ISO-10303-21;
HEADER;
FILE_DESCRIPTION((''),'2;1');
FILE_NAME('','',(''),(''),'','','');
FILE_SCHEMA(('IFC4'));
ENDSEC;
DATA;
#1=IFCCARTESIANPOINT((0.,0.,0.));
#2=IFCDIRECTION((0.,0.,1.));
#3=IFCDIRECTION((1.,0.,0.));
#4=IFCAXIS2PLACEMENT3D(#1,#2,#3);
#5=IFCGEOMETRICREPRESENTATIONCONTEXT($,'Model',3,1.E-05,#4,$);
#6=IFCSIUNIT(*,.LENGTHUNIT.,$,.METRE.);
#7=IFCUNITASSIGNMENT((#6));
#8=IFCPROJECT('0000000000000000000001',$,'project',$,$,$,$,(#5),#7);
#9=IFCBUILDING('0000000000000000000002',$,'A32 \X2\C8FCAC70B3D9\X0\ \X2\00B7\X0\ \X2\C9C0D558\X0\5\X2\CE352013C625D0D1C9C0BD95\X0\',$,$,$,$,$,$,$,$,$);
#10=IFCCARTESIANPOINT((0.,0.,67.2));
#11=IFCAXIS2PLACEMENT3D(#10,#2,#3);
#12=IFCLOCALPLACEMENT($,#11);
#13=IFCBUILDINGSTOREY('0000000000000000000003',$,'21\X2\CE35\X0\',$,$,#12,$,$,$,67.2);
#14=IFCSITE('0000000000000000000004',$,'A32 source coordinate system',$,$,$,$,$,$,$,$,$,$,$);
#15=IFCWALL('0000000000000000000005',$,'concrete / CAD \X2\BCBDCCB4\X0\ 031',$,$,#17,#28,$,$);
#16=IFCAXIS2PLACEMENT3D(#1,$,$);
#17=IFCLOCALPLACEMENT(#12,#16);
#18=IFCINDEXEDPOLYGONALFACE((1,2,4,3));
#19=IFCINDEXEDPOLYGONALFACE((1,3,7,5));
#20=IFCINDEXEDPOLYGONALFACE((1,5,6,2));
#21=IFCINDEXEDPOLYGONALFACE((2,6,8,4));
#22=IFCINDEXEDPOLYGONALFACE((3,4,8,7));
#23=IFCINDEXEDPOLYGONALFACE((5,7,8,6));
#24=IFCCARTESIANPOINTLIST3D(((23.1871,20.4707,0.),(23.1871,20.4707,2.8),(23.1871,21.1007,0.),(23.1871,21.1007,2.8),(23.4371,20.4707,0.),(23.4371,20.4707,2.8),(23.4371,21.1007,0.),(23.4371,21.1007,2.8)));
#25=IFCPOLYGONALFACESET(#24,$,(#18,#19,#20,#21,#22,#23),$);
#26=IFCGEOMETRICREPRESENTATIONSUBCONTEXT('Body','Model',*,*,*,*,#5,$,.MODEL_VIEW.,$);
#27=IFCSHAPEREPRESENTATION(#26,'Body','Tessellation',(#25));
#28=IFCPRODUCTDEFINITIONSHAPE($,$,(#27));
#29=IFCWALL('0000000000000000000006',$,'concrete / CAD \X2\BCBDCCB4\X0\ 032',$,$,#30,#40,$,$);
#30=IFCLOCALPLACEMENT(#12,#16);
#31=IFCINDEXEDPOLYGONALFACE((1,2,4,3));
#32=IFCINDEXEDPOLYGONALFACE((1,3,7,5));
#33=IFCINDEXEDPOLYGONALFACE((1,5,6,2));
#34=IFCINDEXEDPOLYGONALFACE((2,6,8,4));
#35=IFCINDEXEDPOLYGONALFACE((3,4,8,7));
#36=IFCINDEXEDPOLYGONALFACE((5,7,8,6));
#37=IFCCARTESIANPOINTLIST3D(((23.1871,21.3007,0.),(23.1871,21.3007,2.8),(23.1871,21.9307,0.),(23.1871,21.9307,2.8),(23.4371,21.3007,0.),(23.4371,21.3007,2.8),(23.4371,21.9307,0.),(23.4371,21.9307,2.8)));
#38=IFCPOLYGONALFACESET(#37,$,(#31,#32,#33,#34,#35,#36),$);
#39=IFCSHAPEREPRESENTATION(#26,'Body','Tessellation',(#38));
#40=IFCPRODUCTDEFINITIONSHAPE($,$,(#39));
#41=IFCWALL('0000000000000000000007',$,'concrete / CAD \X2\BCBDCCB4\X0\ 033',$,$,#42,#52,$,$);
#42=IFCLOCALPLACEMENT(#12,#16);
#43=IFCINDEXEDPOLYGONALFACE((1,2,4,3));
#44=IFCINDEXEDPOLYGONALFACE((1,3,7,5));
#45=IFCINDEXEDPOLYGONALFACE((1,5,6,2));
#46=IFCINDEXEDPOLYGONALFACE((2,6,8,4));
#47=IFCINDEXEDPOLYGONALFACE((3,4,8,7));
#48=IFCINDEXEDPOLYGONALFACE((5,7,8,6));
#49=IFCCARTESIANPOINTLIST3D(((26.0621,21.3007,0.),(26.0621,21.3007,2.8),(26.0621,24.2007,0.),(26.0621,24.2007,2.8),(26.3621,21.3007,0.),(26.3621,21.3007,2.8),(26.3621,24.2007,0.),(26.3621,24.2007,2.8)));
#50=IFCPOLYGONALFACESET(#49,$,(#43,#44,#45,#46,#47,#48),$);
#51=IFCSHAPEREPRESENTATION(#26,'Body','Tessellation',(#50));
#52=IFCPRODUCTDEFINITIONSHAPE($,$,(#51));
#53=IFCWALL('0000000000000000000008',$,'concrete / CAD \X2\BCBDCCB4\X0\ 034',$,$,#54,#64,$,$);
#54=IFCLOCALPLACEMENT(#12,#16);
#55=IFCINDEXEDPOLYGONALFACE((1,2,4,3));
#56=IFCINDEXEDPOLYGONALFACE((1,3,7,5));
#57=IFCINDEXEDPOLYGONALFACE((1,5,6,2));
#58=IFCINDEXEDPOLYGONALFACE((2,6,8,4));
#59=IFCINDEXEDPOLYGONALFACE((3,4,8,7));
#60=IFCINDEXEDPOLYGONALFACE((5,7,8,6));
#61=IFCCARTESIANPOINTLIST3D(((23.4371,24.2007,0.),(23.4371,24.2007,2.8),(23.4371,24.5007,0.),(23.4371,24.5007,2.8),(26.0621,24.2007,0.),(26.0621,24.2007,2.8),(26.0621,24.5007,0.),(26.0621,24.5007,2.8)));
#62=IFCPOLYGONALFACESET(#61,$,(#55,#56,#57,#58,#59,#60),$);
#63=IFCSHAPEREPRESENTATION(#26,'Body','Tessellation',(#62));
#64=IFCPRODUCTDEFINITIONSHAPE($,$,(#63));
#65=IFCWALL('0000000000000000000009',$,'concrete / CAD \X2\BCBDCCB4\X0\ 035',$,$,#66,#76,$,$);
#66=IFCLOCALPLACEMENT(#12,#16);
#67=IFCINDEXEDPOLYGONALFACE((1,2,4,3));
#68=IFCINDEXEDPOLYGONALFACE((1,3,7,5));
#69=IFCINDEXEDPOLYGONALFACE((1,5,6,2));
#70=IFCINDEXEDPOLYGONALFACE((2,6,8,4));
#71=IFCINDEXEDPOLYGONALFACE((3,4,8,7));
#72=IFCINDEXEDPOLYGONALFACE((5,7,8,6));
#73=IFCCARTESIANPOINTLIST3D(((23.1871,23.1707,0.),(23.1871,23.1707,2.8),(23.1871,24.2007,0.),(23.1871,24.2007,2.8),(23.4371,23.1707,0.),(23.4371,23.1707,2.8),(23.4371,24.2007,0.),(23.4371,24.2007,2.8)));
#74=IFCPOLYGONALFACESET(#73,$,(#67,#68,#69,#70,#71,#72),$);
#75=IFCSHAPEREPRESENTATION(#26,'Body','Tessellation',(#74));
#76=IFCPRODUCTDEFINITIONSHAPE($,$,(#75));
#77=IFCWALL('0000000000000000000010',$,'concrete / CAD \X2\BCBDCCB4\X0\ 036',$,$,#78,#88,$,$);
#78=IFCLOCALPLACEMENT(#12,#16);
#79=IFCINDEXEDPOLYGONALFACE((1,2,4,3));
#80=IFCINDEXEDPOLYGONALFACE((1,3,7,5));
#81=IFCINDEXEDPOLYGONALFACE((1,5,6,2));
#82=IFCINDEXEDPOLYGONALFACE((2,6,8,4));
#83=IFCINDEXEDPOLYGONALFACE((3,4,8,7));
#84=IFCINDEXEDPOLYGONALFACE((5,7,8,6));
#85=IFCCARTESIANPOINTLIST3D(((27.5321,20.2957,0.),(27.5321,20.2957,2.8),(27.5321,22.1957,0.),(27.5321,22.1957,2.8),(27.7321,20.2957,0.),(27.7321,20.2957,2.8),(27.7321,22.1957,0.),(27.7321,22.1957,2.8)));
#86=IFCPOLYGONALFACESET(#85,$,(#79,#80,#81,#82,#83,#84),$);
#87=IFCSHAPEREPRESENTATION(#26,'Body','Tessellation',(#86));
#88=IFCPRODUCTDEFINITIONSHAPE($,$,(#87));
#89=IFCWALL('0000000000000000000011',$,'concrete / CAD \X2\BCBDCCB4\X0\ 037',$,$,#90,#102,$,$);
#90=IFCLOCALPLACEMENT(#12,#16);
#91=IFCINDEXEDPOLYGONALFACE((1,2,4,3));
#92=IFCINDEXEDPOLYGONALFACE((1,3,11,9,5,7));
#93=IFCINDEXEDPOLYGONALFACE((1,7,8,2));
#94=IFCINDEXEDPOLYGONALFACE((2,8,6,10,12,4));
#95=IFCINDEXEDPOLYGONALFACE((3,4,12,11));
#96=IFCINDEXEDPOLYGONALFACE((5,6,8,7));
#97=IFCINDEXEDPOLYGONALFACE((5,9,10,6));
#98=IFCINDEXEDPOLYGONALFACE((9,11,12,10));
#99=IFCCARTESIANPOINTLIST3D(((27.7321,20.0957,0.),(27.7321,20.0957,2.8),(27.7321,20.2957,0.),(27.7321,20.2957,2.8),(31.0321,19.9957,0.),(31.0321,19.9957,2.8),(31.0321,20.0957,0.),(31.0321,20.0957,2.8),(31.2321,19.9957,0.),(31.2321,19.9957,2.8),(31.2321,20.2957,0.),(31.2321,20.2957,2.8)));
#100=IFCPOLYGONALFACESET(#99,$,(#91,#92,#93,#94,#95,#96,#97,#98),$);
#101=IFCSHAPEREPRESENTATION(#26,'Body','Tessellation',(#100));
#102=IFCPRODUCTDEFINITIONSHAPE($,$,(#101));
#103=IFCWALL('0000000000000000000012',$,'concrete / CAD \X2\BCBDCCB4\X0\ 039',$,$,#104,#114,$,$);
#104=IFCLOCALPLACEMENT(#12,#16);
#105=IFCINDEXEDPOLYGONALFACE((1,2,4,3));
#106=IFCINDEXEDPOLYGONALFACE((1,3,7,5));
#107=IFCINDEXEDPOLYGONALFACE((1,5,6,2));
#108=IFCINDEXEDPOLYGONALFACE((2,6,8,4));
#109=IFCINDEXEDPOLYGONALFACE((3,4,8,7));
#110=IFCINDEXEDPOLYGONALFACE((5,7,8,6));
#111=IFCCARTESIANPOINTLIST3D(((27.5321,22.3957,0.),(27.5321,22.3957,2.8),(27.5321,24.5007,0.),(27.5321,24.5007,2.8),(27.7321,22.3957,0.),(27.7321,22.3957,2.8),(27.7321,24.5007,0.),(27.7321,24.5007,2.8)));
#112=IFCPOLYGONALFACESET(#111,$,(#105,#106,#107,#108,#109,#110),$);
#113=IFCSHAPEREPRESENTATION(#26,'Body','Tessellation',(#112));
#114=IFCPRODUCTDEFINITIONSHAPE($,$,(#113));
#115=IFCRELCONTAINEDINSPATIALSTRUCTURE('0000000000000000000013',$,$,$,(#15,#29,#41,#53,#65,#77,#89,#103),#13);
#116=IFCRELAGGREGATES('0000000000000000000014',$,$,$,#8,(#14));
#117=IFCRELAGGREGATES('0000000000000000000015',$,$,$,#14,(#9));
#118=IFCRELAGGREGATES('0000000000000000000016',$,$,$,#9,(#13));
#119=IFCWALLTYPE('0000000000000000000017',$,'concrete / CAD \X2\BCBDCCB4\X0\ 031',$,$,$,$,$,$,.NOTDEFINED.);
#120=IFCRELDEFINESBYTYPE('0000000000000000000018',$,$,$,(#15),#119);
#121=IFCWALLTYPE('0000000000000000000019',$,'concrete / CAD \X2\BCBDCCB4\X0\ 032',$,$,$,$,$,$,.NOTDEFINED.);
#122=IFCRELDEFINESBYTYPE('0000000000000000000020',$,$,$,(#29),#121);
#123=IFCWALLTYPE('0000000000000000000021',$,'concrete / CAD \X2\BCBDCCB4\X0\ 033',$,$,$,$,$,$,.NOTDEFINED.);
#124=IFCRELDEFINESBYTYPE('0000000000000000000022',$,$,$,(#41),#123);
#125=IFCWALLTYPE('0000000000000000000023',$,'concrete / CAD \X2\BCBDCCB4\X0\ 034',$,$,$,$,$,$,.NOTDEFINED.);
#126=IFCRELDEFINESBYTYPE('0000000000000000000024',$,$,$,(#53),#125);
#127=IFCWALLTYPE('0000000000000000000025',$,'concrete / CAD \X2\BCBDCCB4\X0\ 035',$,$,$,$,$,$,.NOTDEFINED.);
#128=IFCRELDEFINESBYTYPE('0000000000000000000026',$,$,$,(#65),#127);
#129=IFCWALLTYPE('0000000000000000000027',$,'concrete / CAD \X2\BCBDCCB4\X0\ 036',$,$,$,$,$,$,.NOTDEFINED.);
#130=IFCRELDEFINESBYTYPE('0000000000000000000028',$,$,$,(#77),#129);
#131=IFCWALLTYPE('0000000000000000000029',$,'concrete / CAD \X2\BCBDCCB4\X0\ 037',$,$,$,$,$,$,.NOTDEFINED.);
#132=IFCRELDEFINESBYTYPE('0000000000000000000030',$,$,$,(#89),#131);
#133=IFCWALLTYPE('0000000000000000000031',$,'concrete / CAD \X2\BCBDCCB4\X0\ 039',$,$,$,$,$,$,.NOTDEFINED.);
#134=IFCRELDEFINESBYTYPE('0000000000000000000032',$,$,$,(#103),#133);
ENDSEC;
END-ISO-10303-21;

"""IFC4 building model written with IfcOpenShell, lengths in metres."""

from ifc_helpers import new_model, si_unit, frame, origin, origin_with_axes, place, context, subcontext, project, spatial, polyline, outline, extrude, source, transform, mapped, type_object, type_shapes, element, save


model = new_model("IFC4")

# Units and contexts
model_context = context("Model", 3, precision=1e-05, world=origin_with_axes())
body_context = subcontext(model_context, "Body", "Model", "MODEL_VIEW")
ifc_project = project(units=[si_unit("LENGTHUNIT", "METRE")], contexts=[model_context])

# Site, building, storey
site = spatial("IfcSite", under=ifc_project, Name="A32 source coordinate system")
building = spatial("IfcBuilding", under=site, Name="A32 주거동 · 지하5층–옥탑지붕")
storey_placement = place(None, frame((0.0, 0.0, 67.2), z_axis=(0.0, 0.0, 1.0), x_axis=(1.0, 0.0, 0.0)))
storey = spatial("IfcBuildingStorey", under=building, at=storey_placement, Name="21층", Elevation=67.2)

# Walls
wall_type_1 = type_object("IfcWallType", Name="concrete / CAD 벽체 031", PredefinedType="NOTDEFINED")
shared_shape_1 = source(origin(), body_context, "Body", "SweptSolid", [
    extrude(outline(polyline([(23.1871, 20.4707), (23.1871, 21.1007), (23.4371, 21.1007), (23.4371, 20.4707), (23.1871, 20.4707)])), origin(), (0.0, 0.0, 1.0), 2.8),
])
type_shapes(wall_type_1, [shared_shape_1])
wall_1_placement = place(storey_placement, origin_with_axes())
element("IfcWall", 1, at=wall_1_placement, inside=storey, type_object=wall_type_1, Name="concrete / CAD 벽체 031", context=body_context, shape_type="MappedRepresentation", body=[
    mapped(shared_shape_1, transform((0.0, 0.0, 0.0), scale=1.0)),
])
wall_type_2 = type_object("IfcWallType", Name="concrete / CAD 벽체 032", PredefinedType="NOTDEFINED")
shared_shape_2 = source(origin(), body_context, "Body", "SweptSolid", [
    extrude(outline(polyline([(23.4371, 21.9307), (23.4371, 21.3007), (23.1871, 21.3007), (23.1871, 21.9307), (23.4371, 21.9307)])), origin(), (0.0, 0.0, 1.0), 2.8),
])
type_shapes(wall_type_2, [shared_shape_2])
wall_2_placement = place(storey_placement, origin_with_axes())
element("IfcWall", 2, at=wall_2_placement, inside=storey, type_object=wall_type_2, Name="concrete / CAD 벽체 032", context=body_context, shape_type="MappedRepresentation", body=[
    mapped(shared_shape_2, transform((0.0, 0.0, 0.0), scale=1.0)),
])
wall_type_3 = type_object("IfcWallType", Name="concrete / CAD 벽체 033", PredefinedType="NOTDEFINED")
shared_shape_3 = source(origin(), body_context, "Body", "SweptSolid", [
    extrude(outline(polyline([(26.3621, 24.2007), (26.3621, 21.3007), (26.0621, 21.3007), (26.0621, 24.2007), (26.3621, 24.2007)])), origin(), (0.0, 0.0, 1.0), 2.8),
])
type_shapes(wall_type_3, [shared_shape_3])
wall_3_placement = place(storey_placement, origin_with_axes())
element("IfcWall", 3, at=wall_3_placement, inside=storey, type_object=wall_type_3, Name="concrete / CAD 벽체 033", context=body_context, shape_type="MappedRepresentation", body=[
    mapped(shared_shape_3, transform((0.0, 0.0, 0.0), scale=1.0)),
])
wall_type_4 = type_object("IfcWallType", Name="concrete / CAD 벽체 034", PredefinedType="NOTDEFINED")
shared_shape_4 = source(origin(), body_context, "Body", "SweptSolid", [
    extrude(outline(polyline([(23.4371, 24.5007), (26.0621, 24.5007), (26.0621, 24.2007), (23.4371, 24.2007), (23.4371, 24.5007)])), origin(), (0.0, 0.0, 1.0), 2.8),
])
type_shapes(wall_type_4, [shared_shape_4])
wall_4_placement = place(storey_placement, origin_with_axes())
element("IfcWall", 4, at=wall_4_placement, inside=storey, type_object=wall_type_4, Name="concrete / CAD 벽체 034", context=body_context, shape_type="MappedRepresentation", body=[
    mapped(shared_shape_4, transform((0.0, 0.0, 0.0), scale=1.0)),
])
wall_type_5 = type_object("IfcWallType", Name="concrete / CAD 벽체 035", PredefinedType="NOTDEFINED")
shared_shape_5 = source(origin(), body_context, "Body", "SweptSolid", [
    extrude(outline(polyline([(23.1871, 23.1707), (23.1871, 24.2007), (23.4371, 24.2007), (23.4371, 23.1707), (23.1871, 23.1707)])), origin(), (0.0, 0.0, 1.0), 2.8),
])
type_shapes(wall_type_5, [shared_shape_5])
wall_5_placement = place(storey_placement, origin_with_axes())
element("IfcWall", 5, at=wall_5_placement, inside=storey, type_object=wall_type_5, Name="concrete / CAD 벽체 035", context=body_context, shape_type="MappedRepresentation", body=[
    mapped(shared_shape_5, transform((0.0, 0.0, 0.0), scale=1.0)),
])
wall_type_6 = type_object("IfcWallType", Name="concrete / CAD 벽체 036", PredefinedType="NOTDEFINED")
shared_shape_6 = source(origin(), body_context, "Body", "SweptSolid", [
    extrude(outline(polyline([(27.7321, 22.1957), (27.7321, 20.2957), (27.5321, 20.2957), (27.5321, 22.1957), (27.7321, 22.1957)])), origin(), (0.0, 0.0, 1.0), 2.8),
])
type_shapes(wall_type_6, [shared_shape_6])
wall_6_placement = place(storey_placement, origin_with_axes())
element("IfcWall", 6, at=wall_6_placement, inside=storey, type_object=wall_type_6, Name="concrete / CAD 벽체 036", context=body_context, shape_type="MappedRepresentation", body=[
    mapped(shared_shape_6, transform((0.0, 0.0, 0.0), scale=1.0)),
])
wall_type_7 = type_object("IfcWallType", Name="concrete / CAD 벽체 037", PredefinedType="NOTDEFINED")
shared_shape_7 = source(origin(), body_context, "Body", "SweptSolid", [
    extrude(outline(polyline([(31.2321, 19.9957), (31.0321, 19.9957), (31.0321, 20.0957), (27.7321, 20.0957), (27.7321, 20.2957), (31.2321, 20.2957), (31.2321, 19.9957)])), origin(), (0.0, 0.0, 1.0), 2.8),
])
type_shapes(wall_type_7, [shared_shape_7])
wall_7_placement = place(storey_placement, origin_with_axes())
element("IfcWall", 7, at=wall_7_placement, inside=storey, type_object=wall_type_7, Name="concrete / CAD 벽체 037", context=body_context, shape_type="MappedRepresentation", body=[
    mapped(shared_shape_7, transform((0.0, 0.0, 0.0), scale=1.0)),
])
wall_type_8 = type_object("IfcWallType", Name="concrete / CAD 벽체 039", PredefinedType="NOTDEFINED")
shared_shape_8 = source(origin(), body_context, "Body", "SweptSolid", [
    extrude(outline(polyline([(27.7321, 24.5007), (27.7321, 22.3957), (27.5321, 22.3957), (27.5321, 24.5007), (27.7321, 24.5007)])), origin(), (0.0, 0.0, 1.0), 2.8),
])
type_shapes(wall_type_8, [shared_shape_8])
wall_8_placement = place(storey_placement, origin_with_axes())
element("IfcWall", 8, at=wall_8_placement, inside=storey, type_object=wall_type_8, Name="concrete / CAD 벽체 039", context=body_context, shape_type="MappedRepresentation", body=[
    mapped(shared_shape_8, transform((0.0, 0.0, 0.0), scale=1.0)),
])

save(model, "model.ifc")
